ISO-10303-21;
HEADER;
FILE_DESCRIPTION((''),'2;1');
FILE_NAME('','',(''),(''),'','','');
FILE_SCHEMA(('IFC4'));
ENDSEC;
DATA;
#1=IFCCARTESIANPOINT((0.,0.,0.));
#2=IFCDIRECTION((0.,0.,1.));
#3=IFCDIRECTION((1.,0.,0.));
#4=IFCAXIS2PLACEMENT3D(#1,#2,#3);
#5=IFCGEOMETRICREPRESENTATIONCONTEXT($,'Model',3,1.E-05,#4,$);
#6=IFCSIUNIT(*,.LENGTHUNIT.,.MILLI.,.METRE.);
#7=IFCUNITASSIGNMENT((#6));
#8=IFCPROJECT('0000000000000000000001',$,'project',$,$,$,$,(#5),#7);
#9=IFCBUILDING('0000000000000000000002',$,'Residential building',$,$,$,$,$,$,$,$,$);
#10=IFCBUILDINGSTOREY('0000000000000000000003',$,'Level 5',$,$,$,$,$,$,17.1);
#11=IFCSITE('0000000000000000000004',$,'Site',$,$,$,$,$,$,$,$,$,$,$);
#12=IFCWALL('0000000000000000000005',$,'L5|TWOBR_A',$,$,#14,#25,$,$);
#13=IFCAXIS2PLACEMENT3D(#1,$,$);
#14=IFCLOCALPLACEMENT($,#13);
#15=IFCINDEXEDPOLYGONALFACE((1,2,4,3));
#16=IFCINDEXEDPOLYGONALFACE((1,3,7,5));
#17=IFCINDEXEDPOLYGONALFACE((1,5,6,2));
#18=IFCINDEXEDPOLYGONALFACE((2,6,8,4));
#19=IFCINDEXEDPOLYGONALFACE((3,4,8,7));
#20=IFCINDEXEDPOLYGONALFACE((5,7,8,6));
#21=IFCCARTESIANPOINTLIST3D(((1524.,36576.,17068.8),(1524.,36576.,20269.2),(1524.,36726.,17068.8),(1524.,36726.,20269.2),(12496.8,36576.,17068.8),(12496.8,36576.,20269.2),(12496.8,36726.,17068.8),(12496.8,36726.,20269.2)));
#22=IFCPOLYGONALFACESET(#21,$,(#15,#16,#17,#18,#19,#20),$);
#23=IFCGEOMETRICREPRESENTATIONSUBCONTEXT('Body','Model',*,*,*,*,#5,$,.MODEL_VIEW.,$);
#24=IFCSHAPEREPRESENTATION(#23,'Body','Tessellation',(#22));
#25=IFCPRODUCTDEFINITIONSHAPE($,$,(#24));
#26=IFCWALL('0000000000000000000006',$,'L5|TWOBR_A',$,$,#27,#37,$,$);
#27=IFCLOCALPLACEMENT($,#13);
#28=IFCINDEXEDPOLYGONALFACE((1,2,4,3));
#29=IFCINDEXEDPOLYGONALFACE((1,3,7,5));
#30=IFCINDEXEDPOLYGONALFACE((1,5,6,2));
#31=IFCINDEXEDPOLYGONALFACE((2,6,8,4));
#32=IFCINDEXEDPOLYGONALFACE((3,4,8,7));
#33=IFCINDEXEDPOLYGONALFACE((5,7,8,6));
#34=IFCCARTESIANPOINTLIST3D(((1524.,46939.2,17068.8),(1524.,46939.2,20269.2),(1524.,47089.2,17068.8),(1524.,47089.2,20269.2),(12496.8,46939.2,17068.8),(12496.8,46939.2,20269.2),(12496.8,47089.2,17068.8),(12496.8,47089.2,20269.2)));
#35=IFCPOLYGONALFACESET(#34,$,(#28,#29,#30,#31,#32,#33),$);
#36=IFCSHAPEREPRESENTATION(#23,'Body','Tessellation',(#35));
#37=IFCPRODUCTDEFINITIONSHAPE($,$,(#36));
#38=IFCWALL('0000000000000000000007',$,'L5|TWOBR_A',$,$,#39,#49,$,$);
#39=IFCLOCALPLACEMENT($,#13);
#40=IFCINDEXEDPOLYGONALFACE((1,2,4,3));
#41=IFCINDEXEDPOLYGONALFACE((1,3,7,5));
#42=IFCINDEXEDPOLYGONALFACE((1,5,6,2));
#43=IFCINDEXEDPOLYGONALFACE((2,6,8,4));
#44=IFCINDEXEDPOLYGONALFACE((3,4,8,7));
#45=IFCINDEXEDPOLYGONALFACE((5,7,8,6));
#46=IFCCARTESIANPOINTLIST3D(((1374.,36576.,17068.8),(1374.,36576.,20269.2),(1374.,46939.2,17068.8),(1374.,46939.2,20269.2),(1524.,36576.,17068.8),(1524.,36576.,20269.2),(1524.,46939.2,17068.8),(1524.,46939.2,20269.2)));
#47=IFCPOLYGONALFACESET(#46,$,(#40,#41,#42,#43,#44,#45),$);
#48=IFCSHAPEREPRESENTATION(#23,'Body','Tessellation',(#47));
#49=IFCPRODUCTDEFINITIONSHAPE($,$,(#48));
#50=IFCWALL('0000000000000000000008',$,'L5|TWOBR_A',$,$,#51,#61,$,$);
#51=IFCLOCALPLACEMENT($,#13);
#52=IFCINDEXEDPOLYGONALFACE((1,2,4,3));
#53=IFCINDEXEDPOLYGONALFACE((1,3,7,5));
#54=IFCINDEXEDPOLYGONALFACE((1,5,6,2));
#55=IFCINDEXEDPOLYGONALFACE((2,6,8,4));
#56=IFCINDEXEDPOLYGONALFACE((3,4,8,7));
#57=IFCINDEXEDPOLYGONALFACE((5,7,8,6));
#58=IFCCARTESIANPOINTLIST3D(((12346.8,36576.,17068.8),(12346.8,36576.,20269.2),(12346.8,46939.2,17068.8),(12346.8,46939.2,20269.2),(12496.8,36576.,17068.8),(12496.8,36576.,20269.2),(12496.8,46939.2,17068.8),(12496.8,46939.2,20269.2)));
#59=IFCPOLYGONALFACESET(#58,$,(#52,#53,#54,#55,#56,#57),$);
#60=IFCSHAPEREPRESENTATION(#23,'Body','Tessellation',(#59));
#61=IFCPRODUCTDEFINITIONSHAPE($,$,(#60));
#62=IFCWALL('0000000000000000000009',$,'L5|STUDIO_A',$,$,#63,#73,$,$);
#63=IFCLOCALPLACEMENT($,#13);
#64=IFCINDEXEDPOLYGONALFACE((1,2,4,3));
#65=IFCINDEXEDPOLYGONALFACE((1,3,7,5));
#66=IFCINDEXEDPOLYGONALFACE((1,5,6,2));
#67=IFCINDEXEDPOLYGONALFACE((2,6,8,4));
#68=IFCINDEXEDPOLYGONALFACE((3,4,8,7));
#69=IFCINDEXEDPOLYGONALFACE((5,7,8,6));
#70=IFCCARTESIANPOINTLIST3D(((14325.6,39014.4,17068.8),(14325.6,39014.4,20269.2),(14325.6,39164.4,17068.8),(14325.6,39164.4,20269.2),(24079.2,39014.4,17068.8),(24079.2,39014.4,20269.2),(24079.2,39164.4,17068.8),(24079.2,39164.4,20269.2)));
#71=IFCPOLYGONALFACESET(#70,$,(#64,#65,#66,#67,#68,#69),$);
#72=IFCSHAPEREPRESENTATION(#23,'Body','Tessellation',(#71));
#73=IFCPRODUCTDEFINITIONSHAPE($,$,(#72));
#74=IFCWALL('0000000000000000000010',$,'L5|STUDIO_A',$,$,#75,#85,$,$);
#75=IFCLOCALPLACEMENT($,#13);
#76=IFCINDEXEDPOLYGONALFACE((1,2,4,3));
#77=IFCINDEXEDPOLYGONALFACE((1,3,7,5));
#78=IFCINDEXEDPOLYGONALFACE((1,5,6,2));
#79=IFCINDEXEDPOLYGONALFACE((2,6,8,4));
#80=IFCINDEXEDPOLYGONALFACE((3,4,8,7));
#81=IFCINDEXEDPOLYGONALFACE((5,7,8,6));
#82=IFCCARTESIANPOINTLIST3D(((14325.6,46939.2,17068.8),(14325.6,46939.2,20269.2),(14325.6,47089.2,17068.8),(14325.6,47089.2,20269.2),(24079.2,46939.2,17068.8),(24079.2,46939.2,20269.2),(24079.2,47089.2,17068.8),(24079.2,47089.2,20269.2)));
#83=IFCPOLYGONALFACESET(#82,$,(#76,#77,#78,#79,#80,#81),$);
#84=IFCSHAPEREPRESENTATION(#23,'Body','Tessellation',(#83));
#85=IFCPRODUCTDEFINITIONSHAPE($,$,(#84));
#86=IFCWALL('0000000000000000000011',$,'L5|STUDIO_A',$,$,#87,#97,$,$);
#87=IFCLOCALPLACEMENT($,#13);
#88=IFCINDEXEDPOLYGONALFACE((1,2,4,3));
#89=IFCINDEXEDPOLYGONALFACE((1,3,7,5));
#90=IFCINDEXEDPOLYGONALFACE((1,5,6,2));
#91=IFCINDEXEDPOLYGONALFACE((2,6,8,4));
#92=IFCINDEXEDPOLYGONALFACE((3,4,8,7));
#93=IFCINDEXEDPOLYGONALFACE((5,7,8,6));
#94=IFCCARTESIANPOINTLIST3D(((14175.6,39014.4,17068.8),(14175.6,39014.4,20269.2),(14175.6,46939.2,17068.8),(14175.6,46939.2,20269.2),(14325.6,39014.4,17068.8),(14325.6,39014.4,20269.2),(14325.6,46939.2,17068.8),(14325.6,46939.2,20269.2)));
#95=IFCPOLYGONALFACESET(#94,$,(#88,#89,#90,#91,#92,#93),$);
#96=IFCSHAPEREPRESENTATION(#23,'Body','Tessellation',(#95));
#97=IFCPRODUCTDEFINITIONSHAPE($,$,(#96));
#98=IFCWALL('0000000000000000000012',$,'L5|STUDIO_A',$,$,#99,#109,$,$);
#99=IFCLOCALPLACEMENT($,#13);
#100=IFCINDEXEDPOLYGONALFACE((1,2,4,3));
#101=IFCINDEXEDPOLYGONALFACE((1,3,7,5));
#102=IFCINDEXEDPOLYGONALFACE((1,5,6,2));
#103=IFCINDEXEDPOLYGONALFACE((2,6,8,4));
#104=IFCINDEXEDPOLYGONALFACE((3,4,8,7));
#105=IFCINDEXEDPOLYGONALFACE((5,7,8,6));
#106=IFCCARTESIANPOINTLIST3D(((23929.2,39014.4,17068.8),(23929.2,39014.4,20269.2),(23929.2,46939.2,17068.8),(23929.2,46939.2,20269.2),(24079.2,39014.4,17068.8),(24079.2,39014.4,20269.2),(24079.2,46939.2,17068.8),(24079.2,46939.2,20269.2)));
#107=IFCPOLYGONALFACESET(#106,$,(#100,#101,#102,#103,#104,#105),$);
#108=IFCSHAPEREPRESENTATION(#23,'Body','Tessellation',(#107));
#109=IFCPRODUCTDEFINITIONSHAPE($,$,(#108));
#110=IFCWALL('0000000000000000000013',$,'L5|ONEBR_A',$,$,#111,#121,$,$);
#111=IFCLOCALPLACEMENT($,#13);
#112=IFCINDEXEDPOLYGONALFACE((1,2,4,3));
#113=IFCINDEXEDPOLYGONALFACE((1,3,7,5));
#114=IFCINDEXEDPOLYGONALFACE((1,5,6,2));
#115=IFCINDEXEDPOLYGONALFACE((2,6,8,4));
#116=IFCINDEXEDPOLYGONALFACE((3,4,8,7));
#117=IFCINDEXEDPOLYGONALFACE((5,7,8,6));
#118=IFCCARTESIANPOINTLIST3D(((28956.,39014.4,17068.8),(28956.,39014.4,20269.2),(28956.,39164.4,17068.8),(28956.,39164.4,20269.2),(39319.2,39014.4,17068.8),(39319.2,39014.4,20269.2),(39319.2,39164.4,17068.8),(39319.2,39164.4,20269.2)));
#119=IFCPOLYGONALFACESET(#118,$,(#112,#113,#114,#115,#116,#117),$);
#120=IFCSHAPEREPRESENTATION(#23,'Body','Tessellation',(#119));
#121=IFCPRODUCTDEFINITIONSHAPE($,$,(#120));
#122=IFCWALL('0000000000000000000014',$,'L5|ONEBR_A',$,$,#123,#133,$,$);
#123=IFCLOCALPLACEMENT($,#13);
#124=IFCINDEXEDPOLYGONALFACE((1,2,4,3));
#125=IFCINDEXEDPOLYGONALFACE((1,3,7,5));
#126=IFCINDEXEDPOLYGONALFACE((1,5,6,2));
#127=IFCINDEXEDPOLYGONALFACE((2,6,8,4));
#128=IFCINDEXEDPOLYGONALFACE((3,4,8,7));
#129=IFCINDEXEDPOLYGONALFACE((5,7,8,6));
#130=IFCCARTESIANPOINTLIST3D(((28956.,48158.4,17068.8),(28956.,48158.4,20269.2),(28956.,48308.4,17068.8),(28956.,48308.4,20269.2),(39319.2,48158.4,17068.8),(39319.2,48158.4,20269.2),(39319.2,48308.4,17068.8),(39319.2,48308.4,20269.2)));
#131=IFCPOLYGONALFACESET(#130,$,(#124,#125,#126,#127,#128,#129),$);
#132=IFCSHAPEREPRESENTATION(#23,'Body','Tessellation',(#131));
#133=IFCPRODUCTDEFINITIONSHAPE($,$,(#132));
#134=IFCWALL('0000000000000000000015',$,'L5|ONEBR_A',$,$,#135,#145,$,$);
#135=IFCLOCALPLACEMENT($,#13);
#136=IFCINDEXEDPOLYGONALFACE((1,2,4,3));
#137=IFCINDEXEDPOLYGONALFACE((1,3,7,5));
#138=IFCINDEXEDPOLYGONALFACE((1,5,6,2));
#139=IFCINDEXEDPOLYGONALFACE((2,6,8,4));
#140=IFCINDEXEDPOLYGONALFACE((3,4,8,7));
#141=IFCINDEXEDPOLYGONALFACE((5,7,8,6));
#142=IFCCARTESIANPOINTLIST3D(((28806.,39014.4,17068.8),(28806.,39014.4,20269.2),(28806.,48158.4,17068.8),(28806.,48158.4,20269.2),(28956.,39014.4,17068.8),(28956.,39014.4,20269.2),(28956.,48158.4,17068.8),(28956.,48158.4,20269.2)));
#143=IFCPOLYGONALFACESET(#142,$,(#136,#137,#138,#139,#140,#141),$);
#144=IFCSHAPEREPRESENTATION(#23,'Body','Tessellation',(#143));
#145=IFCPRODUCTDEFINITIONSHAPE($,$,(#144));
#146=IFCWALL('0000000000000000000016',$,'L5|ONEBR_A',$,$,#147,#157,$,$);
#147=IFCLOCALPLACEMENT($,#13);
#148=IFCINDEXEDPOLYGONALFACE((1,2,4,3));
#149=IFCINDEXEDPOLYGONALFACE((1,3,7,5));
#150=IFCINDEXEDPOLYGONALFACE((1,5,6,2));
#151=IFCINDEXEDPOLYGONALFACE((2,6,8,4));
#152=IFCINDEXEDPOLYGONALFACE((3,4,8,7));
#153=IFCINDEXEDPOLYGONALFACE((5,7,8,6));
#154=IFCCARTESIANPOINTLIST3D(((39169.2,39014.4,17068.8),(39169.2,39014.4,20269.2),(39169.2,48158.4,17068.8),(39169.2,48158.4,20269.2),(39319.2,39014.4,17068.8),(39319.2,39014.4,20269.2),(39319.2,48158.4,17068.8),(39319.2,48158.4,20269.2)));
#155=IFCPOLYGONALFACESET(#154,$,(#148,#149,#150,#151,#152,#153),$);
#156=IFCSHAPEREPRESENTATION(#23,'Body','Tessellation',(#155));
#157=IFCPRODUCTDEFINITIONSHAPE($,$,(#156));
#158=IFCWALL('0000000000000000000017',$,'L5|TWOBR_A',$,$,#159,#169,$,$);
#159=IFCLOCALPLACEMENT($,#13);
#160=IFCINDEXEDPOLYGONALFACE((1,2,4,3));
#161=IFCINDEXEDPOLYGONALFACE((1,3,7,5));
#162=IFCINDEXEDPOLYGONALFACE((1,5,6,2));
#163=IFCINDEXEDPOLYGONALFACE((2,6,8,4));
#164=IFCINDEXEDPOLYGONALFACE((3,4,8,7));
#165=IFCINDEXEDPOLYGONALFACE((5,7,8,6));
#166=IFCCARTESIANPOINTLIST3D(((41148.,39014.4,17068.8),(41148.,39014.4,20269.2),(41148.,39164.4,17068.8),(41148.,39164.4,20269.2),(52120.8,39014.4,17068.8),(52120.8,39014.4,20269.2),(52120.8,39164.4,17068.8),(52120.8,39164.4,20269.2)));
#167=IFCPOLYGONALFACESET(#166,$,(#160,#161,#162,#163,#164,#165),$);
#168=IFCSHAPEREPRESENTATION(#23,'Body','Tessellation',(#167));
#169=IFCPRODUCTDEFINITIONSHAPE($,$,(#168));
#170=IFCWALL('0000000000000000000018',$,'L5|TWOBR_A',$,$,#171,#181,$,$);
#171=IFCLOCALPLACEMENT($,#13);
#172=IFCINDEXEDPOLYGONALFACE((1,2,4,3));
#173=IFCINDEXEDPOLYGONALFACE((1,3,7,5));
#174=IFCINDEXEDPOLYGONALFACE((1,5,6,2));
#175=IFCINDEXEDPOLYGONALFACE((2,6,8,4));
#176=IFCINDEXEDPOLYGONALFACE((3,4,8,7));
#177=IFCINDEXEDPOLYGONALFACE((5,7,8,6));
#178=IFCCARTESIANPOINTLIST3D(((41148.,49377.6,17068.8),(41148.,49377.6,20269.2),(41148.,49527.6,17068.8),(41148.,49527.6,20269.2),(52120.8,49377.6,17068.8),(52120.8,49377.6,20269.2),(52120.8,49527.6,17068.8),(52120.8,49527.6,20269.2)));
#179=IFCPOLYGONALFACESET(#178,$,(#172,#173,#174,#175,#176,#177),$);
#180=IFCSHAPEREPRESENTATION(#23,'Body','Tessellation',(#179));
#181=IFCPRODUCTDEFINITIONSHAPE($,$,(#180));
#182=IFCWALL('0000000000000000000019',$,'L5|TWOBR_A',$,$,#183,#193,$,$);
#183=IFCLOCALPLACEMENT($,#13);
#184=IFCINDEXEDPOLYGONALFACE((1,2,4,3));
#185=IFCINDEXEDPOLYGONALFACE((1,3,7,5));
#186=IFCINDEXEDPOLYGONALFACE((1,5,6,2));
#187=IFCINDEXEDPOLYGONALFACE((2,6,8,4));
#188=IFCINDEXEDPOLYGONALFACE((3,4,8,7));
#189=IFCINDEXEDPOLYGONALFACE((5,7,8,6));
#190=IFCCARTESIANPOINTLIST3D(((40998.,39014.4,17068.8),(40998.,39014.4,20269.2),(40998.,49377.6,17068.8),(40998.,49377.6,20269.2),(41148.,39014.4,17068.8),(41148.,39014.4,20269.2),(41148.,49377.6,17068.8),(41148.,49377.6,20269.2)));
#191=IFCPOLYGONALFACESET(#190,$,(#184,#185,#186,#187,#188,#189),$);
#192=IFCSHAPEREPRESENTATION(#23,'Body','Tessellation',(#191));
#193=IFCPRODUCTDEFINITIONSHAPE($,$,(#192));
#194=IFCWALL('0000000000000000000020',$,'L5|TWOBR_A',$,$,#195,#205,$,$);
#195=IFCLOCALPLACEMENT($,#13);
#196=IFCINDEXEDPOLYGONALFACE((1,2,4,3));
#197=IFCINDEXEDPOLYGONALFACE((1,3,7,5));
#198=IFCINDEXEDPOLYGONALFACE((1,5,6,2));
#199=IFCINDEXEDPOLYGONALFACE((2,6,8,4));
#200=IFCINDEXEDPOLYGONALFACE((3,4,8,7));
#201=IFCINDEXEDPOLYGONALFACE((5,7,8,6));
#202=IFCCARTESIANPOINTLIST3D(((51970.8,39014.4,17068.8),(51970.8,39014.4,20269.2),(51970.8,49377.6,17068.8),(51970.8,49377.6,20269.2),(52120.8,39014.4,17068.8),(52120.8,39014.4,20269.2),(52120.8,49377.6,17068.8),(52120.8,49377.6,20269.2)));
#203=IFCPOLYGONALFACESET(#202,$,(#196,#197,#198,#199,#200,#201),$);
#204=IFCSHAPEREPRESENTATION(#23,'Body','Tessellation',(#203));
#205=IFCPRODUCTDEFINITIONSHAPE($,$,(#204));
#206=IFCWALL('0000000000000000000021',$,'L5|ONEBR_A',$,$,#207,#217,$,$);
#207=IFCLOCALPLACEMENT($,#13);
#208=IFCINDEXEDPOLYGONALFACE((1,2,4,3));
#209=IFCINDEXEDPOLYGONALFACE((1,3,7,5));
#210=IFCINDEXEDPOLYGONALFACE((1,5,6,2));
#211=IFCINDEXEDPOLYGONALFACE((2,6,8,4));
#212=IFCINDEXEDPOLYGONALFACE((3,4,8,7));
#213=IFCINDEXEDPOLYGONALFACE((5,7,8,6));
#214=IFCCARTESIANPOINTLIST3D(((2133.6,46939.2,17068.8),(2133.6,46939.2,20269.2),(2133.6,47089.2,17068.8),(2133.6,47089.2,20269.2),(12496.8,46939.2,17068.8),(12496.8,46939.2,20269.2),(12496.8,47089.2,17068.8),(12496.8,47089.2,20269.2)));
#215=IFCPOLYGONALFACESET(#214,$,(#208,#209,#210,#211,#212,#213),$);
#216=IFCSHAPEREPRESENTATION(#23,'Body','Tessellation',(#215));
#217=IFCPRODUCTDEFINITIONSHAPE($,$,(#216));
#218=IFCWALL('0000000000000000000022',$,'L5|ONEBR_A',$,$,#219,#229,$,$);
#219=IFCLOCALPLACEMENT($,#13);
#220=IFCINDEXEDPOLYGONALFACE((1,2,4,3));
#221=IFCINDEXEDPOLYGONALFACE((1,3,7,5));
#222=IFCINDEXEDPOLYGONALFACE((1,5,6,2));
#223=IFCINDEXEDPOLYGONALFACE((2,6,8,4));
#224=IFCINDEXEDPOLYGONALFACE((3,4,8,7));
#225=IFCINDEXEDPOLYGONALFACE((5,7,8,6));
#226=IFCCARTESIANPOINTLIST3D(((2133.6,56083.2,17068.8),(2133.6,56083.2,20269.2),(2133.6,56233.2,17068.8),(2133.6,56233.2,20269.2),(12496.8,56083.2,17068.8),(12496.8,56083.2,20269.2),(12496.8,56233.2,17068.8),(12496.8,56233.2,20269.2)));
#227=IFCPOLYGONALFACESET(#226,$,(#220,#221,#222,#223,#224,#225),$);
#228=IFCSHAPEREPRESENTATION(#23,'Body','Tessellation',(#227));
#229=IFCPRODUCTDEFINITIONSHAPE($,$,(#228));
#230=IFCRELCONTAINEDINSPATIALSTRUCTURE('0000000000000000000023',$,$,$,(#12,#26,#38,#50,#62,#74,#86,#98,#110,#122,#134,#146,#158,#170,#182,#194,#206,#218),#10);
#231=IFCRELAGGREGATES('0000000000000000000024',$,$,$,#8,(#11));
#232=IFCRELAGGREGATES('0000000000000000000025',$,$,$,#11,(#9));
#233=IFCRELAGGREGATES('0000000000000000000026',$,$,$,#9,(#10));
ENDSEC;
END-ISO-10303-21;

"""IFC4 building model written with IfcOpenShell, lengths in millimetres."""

from ifc_helpers import new_model, si_unit, frame, origin_with_axes, place, context, subcontext, project, spatial, indexed_curve, outline, extrude, element, save


model = new_model("IFC4")

# Units and contexts
model_context = context("Model", 3, precision=1e-05, world=origin_with_axes())
body_context = subcontext(model_context, "Body", "Model", "MODEL_VIEW")
ifc_project = project(units=[si_unit("LENGTHUNIT", "METRE", prefix="MILLI")], contexts=[model_context])

# Site, building, storey
site = spatial("IfcSite", under=ifc_project, Name="Site")
building = spatial("IfcBuilding", under=site, Name="Residential building")
storey = spatial("IfcBuildingStorey", under=building, Name="Level 5", Elevation=17.1)

# Walls
for number, where, z_axis, x_axis, name in (
    (1, (1524.0, 36576.0, 17068.8), (0.0, 0.0, 1.0), (1.0, 0.0, 0.0), "L5|TWOBR_A"),
    (2, (1524.0, 46939.2, 17068.8), (0.0, 0.0, 1.0), (1.0, 0.0, 0.0), "L5|TWOBR_A"),
):
    element("IfcWall", number, at=place(None, frame(where, z_axis=z_axis, x_axis=x_axis)), inside=storey, Name=name, context=body_context, shape_type="SweptSolid", body=[
        extrude(outline(indexed_curve([(0.0, 0.0), (0.0, 150.0), (10972.8, 150.0), (10972.8, 0.0), (0.0, 0.0)], self_intersect=False)), origin_with_axes(), (0.0, 0.0, 1.0), 3200.4),
    ])
for number, where, z_axis, x_axis, name in (
    (3, (1524.0, 36576.0, 17068.8), (0.0, 0.0, 1.0), (0.0, 1.0, 0.0), "L5|TWOBR_A"),
    (4, (12496.8, 36576.0, 17068.8), (0.0, 0.0, 1.0), (0.0, 1.0, 0.0), "L5|TWOBR_A"),
):
    element("IfcWall", number, at=place(None, frame(where, z_axis=z_axis, x_axis=x_axis)), inside=storey, Name=name, context=body_context, shape_type="SweptSolid", body=[
        extrude(outline(indexed_curve([(0.0, 0.0), (0.0, 150.0), (10363.2, 150.0), (10363.2, 0.0), (0.0, 0.0)], self_intersect=False)), origin_with_axes(), (0.0, 0.0, 1.0), 3200.4),
    ])
for number, where, z_axis, x_axis, name in (
    (5, (14325.6, 39014.4, 17068.8), (0.0, 0.0, 1.0), (1.0, 0.0, 0.0), "L5|STUDIO_A"),
    (6, (14325.6, 46939.2, 17068.8), (0.0, 0.0, 1.0), (1.0, 0.0, 0.0), "L5|STUDIO_A"),
):
    element("IfcWall", number, at=place(None, frame(where, z_axis=z_axis, x_axis=x_axis)), inside=storey, Name=name, context=body_context, shape_type="SweptSolid", body=[
        extrude(outline(indexed_curve([(0.0, 0.0), (0.0, 150.0), (9753.6, 150.0), (9753.6, 0.0), (0.0, 0.0)], self_intersect=False)), origin_with_axes(), (0.0, 0.0, 1.0), 3200.4),
    ])
for number, where, z_axis, x_axis, name in (
    (7, (14325.6, 39014.4, 17068.8), (0.0, 0.0, 1.0), (0.0, 1.0, 0.0), "L5|STUDIO_A"),
    (8, (24079.2, 39014.4, 17068.8), (0.0, 0.0, 1.0), (0.0, 1.0, 0.0), "L5|STUDIO_A"),
):
    element("IfcWall", number, at=place(None, frame(where, z_axis=z_axis, x_axis=x_axis)), inside=storey, Name=name, context=body_context, shape_type="SweptSolid", body=[
        extrude(outline(indexed_curve([(0.0, 0.0), (0.0, 150.0), (7924.8, 150.0), (7924.8, 0.0), (0.0, 0.0)], self_intersect=False)), origin_with_axes(), (0.0, 0.0, 1.0), 3200.4),
    ])
for number, where, z_axis, x_axis, name in (
    (9, (28956.0, 39014.4, 17068.8), (0.0, 0.0, 1.0), (1.0, 0.0, 0.0), "L5|ONEBR_A"),
    (10, (28956.0, 48158.4, 17068.8), (0.0, 0.0, 1.0), (1.0, 0.0, 0.0), "L5|ONEBR_A"),
):
    element("IfcWall", number, at=place(None, frame(where, z_axis=z_axis, x_axis=x_axis)), inside=storey, Name=name, context=body_context, shape_type="SweptSolid", body=[
        extrude(outline(indexed_curve([(0.0, 0.0), (0.0, 150.0), (10363.2, 150.0), (10363.2, 0.0), (0.0, 0.0)], self_intersect=False)), origin_with_axes(), (0.0, 0.0, 1.0), 3200.4),
    ])
for number, where, z_axis, x_axis, name in (
    (11, (28956.0, 39014.4, 17068.8), (0.0, 0.0, 1.0), (0.0, 1.0, 0.0), "L5|ONEBR_A"),
    (12, (39319.2, 39014.4, 17068.8), (0.0, 0.0, 1.0), (0.0, 1.0, 0.0), "L5|ONEBR_A"),
):
    element("IfcWall", number, at=place(None, frame(where, z_axis=z_axis, x_axis=x_axis)), inside=storey, Name=name, context=body_context, shape_type="SweptSolid", body=[
        extrude(outline(indexed_curve([(0.0, 0.0), (0.0, 150.0), (9144.0, 150.0), (9144.0, 0.0), (0.0, 0.0)], self_intersect=False)), origin_with_axes(), (0.0, 0.0, 1.0), 3200.4),
    ])
for number, where, z_axis, x_axis, name in (
    (13, (41148.0, 39014.4, 17068.8), (0.0, 0.0, 1.0), (1.0, 0.0, 0.0), "L5|TWOBR_A"),
    (14, (41148.0, 49377.6, 17068.8), (0.0, 0.0, 1.0), (1.0, 0.0, 0.0), "L5|TWOBR_A"),
):
    element("IfcWall", number, at=place(None, frame(where, z_axis=z_axis, x_axis=x_axis)), inside=storey, Name=name, context=body_context, shape_type="SweptSolid", body=[
        extrude(outline(indexed_curve([(0.0, 0.0), (0.0, 150.0), (10972.8, 150.0), (10972.8, 0.0), (0.0, 0.0)], self_intersect=False)), origin_with_axes(), (0.0, 0.0, 1.0), 3200.4),
    ])
for number, where, z_axis, x_axis, name in (
    (15, (41148.0, 39014.4, 17068.8), (0.0, 0.0, 1.0), (0.0, 1.0, 0.0), "L5|TWOBR_A"),
    (16, (52120.8, 39014.4, 17068.8), (0.0, 0.0, 1.0), (0.0, 1.0, 0.0), "L5|TWOBR_A"),
    (17, (2133.6, 46939.2, 17068.8), (0.0, 0.0, 1.0), (1.0, 0.0, 0.0), "L5|ONEBR_A"),
    (18, (2133.6, 56083.2, 17068.8), (0.0, 0.0, 1.0), (1.0, 0.0, 0.0), "L5|ONEBR_A"),
):
    element("IfcWall", number, at=place(None, frame(where, z_axis=z_axis, x_axis=x_axis)), inside=storey, Name=name, context=body_context, shape_type="SweptSolid", body=[
        extrude(outline(indexed_curve([(0.0, 0.0), (0.0, 150.0), (10363.2, 150.0), (10363.2, 0.0), (0.0, 0.0)], self_intersect=False)), origin_with_axes(), (0.0, 0.0, 1.0), 3200.4),
    ])

save(model, "model.ifc")
